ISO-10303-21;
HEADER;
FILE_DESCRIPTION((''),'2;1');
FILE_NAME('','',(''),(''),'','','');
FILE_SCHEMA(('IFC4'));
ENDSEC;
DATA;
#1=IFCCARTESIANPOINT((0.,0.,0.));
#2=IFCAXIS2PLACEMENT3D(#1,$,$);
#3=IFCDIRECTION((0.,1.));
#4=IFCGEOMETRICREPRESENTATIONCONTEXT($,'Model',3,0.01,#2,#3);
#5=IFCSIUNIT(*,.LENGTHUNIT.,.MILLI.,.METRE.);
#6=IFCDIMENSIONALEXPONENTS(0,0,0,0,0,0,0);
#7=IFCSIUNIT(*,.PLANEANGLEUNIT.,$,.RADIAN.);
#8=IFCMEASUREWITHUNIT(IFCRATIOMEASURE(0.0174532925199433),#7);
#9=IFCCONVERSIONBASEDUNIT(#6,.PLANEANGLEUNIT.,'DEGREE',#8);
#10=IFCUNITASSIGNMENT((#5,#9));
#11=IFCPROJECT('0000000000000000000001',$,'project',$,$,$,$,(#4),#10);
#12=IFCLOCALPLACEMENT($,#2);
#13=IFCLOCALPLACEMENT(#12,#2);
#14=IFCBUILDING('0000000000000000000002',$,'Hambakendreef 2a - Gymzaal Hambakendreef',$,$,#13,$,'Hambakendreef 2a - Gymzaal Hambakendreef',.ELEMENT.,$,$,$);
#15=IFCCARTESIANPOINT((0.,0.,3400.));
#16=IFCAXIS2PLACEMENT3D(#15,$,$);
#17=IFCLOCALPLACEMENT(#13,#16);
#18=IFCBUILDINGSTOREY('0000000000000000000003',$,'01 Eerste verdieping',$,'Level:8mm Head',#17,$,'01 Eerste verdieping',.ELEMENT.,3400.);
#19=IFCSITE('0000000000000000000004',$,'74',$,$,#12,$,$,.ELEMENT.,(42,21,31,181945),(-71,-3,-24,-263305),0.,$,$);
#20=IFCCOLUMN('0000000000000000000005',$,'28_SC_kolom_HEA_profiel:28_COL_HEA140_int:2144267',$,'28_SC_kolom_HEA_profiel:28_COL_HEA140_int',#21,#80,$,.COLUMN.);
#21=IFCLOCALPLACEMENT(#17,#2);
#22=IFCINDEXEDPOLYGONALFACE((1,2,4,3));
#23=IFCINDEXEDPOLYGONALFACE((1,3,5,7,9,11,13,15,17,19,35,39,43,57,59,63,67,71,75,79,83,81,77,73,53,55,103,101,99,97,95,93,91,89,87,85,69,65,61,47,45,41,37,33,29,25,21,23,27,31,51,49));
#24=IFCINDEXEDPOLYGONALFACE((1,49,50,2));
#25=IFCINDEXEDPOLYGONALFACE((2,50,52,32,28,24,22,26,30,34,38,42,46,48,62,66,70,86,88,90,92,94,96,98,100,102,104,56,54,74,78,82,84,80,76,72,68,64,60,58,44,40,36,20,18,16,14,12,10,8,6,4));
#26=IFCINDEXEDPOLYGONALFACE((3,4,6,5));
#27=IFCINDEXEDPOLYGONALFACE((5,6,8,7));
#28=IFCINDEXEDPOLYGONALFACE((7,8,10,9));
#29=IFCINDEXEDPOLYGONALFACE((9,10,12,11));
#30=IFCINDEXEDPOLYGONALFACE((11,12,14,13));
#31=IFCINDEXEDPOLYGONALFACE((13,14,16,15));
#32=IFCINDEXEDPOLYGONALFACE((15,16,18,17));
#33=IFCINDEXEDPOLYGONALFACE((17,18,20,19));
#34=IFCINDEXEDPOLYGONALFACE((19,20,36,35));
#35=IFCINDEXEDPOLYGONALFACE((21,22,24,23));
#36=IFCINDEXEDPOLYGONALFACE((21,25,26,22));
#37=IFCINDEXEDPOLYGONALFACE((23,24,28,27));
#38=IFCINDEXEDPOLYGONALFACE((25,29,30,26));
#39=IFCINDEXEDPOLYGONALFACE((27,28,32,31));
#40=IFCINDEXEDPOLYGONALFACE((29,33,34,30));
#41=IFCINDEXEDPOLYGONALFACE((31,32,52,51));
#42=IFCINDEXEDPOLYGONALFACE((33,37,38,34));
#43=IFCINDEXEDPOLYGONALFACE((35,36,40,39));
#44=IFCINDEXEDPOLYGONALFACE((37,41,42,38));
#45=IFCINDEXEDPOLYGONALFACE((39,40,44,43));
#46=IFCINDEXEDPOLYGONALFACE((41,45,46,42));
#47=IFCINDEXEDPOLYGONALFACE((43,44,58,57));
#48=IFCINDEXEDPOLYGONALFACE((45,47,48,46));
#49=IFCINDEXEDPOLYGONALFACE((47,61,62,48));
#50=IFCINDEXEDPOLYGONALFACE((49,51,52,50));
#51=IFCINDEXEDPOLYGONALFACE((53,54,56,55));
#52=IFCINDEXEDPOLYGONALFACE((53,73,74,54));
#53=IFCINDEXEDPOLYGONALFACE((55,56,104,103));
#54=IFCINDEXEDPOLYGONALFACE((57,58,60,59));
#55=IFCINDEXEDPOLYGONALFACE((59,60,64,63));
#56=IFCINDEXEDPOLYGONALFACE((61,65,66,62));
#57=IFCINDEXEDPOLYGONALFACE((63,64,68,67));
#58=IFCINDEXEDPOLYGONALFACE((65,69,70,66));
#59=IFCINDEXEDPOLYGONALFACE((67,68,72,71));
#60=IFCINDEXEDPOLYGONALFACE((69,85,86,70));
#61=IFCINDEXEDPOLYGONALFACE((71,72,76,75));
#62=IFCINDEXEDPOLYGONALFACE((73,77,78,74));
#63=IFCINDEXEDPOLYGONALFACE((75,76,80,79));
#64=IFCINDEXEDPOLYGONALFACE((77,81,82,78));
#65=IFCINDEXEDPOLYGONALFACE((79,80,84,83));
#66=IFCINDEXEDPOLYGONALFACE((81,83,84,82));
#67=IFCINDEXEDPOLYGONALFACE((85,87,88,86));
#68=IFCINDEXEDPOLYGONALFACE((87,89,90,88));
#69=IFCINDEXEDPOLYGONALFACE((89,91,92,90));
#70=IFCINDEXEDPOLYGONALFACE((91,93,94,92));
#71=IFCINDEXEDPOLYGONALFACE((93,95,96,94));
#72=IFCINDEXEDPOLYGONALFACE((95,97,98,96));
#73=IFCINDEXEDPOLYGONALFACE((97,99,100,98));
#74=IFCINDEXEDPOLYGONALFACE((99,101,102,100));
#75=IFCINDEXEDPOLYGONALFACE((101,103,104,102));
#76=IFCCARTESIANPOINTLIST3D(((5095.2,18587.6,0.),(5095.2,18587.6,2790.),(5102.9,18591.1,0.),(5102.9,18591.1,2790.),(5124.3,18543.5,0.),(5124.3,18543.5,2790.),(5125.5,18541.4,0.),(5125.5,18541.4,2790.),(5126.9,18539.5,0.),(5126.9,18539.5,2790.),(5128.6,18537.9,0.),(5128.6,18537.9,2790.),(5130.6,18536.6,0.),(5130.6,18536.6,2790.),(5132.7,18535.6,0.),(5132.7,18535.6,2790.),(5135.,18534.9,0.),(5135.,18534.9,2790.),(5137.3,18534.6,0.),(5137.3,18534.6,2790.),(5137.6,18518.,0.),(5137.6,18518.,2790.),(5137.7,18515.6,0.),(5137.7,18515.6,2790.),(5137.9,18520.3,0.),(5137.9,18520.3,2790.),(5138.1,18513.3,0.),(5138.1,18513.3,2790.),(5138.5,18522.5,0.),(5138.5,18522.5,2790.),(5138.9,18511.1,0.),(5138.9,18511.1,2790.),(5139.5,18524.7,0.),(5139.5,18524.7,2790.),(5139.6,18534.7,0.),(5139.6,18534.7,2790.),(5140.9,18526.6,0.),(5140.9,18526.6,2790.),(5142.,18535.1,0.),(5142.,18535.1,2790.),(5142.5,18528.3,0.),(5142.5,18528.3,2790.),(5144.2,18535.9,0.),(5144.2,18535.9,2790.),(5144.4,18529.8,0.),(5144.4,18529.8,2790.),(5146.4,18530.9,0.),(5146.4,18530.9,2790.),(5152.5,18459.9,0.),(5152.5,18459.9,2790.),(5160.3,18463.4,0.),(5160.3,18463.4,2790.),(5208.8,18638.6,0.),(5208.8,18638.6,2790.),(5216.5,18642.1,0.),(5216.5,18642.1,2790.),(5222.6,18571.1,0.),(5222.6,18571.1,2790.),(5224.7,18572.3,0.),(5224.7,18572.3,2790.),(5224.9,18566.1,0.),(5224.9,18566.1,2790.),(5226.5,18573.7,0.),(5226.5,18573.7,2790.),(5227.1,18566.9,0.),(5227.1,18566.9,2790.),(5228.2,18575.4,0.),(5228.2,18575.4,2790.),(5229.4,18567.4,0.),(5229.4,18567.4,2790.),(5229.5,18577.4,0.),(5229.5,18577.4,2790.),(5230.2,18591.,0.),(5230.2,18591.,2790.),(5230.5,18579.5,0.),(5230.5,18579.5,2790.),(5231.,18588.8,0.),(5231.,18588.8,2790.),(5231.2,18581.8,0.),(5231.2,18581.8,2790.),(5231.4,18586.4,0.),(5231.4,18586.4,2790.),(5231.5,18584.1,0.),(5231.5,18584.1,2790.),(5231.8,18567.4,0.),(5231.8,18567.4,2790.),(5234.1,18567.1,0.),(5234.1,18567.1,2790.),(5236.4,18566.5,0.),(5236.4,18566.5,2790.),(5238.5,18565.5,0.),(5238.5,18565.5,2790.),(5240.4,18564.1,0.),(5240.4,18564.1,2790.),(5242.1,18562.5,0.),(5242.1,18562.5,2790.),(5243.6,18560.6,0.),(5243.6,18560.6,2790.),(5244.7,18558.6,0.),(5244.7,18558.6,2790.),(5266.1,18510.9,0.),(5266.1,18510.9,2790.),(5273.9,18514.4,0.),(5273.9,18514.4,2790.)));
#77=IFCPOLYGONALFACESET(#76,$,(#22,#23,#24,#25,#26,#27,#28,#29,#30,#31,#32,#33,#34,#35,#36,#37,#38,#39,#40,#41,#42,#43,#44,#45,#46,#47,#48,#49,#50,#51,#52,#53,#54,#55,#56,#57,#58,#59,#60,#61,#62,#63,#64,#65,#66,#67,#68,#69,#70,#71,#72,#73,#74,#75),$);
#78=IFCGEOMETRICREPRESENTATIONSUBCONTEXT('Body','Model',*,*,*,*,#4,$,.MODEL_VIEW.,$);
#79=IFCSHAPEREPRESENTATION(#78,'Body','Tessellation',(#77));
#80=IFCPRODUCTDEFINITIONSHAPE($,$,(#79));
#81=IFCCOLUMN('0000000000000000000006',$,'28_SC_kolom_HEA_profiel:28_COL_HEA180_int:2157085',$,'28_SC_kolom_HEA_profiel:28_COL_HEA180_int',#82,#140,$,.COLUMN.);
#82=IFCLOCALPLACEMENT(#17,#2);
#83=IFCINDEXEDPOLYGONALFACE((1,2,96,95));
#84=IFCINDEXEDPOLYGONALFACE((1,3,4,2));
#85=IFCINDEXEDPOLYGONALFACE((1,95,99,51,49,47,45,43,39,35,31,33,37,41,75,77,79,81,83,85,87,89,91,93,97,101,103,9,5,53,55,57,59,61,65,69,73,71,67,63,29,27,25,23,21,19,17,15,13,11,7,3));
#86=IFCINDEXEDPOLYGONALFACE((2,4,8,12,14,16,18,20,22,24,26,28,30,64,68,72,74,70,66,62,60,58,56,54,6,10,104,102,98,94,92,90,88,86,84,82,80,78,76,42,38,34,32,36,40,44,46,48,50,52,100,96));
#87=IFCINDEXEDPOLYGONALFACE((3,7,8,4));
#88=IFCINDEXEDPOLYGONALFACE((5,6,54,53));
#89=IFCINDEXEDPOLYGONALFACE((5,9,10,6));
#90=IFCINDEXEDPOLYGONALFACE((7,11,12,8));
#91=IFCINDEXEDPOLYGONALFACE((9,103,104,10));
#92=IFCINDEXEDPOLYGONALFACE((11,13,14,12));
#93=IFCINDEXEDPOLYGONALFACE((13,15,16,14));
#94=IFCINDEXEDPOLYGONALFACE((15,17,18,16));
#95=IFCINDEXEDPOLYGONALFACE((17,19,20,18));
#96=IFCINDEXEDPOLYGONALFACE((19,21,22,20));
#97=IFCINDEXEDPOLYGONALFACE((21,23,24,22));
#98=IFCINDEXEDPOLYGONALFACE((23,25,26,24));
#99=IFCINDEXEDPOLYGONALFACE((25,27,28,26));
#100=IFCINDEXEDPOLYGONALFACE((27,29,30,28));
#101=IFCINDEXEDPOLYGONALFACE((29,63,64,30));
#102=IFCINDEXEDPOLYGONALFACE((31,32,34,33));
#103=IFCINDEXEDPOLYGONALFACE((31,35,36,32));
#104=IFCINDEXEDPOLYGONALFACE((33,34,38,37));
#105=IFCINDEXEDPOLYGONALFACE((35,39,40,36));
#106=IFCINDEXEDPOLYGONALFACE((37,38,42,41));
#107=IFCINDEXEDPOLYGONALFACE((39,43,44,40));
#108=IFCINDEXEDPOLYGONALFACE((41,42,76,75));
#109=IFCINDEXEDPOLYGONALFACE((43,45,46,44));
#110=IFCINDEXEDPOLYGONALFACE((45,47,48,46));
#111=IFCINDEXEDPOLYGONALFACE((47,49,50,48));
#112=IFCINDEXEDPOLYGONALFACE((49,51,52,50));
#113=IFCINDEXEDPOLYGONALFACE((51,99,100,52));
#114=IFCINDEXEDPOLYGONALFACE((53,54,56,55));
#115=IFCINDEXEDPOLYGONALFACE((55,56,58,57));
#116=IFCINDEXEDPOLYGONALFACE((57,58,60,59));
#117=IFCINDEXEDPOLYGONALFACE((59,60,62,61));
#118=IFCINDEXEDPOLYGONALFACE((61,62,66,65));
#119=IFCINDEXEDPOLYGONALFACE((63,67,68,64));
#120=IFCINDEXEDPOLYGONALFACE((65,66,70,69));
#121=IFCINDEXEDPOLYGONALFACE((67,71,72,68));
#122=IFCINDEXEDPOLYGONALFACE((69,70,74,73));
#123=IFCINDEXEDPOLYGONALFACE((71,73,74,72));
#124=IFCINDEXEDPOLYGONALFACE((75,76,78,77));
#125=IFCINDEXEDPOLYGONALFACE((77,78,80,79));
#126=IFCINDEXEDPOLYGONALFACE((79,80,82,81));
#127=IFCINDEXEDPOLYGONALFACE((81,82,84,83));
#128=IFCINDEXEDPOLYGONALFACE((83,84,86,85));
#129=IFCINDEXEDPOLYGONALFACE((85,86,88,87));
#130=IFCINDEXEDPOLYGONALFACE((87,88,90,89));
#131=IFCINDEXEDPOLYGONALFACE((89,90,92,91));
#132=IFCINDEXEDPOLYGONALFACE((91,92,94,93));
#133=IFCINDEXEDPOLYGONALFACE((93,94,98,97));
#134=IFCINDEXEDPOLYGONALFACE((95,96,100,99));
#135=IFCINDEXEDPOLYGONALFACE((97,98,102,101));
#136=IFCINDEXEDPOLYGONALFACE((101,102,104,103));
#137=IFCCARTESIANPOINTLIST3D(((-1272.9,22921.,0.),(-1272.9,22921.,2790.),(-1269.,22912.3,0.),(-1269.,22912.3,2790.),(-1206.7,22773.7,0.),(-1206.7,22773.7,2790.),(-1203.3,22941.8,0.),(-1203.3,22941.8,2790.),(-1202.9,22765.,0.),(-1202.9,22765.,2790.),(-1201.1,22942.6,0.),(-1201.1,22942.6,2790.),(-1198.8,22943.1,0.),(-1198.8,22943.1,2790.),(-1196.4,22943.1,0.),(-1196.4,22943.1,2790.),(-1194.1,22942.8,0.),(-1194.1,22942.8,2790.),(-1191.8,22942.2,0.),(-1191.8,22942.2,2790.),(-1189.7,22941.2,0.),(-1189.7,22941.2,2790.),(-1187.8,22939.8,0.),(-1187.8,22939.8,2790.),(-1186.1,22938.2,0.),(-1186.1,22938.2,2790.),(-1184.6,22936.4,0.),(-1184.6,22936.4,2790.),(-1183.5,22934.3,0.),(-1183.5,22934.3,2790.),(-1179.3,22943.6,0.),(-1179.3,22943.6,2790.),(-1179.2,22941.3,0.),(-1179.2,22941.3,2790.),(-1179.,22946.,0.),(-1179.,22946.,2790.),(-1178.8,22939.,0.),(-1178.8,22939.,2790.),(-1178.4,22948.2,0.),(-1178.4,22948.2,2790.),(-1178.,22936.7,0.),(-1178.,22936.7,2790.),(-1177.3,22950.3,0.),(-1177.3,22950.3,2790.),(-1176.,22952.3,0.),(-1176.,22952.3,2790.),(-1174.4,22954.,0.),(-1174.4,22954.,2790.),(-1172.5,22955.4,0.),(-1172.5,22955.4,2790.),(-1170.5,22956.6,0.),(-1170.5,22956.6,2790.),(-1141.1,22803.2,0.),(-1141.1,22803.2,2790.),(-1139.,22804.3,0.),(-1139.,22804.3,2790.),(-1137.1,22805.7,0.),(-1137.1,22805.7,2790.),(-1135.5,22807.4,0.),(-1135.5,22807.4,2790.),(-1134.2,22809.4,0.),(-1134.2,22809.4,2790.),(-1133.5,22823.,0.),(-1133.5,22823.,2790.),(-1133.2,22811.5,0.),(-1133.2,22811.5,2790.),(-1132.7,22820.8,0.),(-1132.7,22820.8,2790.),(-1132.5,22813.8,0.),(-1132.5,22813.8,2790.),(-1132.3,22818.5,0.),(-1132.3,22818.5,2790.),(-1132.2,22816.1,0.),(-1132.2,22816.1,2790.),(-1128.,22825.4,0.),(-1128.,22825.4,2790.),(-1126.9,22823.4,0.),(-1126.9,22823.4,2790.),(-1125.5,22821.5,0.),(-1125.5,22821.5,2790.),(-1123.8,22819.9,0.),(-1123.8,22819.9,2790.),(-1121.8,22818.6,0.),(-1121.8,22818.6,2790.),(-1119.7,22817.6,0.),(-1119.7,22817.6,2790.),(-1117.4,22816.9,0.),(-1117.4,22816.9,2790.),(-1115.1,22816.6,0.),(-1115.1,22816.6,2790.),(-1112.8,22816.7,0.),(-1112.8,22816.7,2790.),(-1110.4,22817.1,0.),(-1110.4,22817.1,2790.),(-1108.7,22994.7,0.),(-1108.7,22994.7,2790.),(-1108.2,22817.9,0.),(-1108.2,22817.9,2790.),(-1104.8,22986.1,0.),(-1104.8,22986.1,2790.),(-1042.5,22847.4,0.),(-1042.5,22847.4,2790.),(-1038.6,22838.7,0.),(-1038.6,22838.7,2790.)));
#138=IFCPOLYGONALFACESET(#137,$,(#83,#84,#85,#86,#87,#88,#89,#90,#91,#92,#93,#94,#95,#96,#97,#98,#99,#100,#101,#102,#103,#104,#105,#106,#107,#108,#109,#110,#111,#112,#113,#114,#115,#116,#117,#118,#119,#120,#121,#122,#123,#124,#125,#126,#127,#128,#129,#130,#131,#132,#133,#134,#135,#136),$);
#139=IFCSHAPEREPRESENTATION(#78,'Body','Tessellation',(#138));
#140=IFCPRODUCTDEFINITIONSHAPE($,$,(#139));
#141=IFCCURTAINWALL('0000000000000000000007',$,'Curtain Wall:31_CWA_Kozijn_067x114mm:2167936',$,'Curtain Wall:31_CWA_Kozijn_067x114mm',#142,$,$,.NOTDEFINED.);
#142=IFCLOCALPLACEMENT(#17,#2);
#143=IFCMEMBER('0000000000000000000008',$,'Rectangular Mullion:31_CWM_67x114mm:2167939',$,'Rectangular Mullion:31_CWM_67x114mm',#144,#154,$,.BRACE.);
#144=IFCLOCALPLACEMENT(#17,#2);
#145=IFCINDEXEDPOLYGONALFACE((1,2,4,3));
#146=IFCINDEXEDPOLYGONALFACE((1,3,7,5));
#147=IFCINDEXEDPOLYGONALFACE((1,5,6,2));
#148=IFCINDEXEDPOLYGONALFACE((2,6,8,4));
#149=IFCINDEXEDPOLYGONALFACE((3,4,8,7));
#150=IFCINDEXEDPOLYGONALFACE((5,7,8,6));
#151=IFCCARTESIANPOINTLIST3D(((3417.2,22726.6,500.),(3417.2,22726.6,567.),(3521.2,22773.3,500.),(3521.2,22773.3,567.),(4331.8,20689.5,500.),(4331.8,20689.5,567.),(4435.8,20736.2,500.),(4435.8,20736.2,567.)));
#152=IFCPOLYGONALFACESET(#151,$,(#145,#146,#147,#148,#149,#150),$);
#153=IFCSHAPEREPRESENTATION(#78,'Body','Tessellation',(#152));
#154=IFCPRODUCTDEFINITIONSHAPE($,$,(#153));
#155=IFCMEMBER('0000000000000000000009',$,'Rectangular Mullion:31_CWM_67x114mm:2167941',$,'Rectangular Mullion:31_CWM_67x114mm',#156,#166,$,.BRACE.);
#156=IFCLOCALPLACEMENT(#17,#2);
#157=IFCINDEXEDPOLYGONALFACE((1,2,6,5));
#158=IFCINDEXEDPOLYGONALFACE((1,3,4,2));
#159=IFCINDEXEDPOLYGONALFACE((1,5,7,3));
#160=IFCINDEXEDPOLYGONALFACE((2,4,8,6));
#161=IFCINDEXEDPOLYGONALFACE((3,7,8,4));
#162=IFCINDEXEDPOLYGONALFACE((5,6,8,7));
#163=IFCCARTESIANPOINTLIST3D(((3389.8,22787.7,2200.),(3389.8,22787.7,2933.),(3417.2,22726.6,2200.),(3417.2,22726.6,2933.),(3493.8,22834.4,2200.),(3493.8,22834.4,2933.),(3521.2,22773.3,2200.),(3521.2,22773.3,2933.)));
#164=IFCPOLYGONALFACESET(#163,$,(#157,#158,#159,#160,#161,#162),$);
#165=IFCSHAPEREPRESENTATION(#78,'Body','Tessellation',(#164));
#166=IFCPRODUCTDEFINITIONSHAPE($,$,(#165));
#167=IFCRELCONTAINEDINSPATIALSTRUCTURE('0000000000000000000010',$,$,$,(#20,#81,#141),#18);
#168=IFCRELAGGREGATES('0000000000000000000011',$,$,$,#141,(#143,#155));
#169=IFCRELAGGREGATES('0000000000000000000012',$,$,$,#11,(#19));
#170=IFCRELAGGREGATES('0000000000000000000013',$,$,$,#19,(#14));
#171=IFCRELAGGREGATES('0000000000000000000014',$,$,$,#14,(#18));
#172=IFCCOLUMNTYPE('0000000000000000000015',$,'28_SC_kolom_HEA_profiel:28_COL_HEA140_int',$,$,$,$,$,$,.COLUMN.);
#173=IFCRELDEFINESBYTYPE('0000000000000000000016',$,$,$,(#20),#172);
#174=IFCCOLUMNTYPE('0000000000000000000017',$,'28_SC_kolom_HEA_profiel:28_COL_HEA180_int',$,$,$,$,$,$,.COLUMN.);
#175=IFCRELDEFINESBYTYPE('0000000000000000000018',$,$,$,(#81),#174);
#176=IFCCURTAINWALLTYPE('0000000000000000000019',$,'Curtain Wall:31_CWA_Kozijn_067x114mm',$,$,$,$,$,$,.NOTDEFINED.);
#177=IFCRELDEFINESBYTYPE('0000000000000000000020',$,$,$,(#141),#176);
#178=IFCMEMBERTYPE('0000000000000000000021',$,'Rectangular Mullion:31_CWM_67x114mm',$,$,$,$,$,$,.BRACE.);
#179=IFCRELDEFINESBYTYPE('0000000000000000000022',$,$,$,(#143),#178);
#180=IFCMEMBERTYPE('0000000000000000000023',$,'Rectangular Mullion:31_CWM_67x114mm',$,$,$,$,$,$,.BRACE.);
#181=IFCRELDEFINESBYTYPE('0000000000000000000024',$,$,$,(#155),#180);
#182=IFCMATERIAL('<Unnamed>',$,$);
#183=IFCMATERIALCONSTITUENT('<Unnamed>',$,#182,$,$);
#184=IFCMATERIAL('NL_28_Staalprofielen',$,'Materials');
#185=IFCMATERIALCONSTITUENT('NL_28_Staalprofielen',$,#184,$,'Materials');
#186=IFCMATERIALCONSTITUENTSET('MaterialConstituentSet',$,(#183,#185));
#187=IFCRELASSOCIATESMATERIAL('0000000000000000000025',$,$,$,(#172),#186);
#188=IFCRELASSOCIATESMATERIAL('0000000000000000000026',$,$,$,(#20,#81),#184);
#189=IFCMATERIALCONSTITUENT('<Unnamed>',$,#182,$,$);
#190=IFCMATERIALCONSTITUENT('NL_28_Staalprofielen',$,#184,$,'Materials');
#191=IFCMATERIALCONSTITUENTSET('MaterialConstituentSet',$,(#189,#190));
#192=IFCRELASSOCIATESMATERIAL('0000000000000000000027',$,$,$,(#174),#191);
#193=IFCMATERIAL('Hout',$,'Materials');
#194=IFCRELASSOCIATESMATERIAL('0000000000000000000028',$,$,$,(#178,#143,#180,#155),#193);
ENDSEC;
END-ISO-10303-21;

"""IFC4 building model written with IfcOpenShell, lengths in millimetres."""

from ifc_helpers import new_model, entity, si_unit, converted_unit, direction, frame, origin, place, context, subcontext, project, spatial, indexed_curve, outline, extrude, source, transform, mapped, material, constituent, constituent_set, type_object, type_shapes, element, aggregate, save


model = new_model("IFC4")

# Units and contexts
model_context = context("Model", 3, precision=0.01, world=origin(), true_north=direction((0.0, 1.0)))
body_context = subcontext(model_context, "Body", "Model", "MODEL_VIEW")
ifc_project = project(units=[si_unit("LENGTHUNIT", "METRE", prefix="MILLI"), converted_unit("PLANEANGLEUNIT", "DEGREE", entity("IfcRatioMeasure", 0.0174532925199433), si_unit("PLANEANGLEUNIT", "RADIAN"), dimensions=[0, 0, 0, 0, 0, 0, 0])], contexts=[model_context])

# Site, building, storey
site_placement = place(None, origin())
site = spatial("IfcSite", under=ifc_project, at=site_placement, Name="74", CompositionType="ELEMENT", RefLatitude=(42, 21, 31, 181945), RefLongitude=(-71, -3, -24, -263305), RefElevation=0.0)
building_placement = place(site_placement, origin())
building = spatial("IfcBuilding", under=site, at=building_placement, Name="Hambakendreef 2a - Gymzaal Hambakendreef", LongName="Hambakendreef 2a - Gymzaal Hambakendreef", CompositionType="ELEMENT")
storey_placement = place(building_placement, frame((0.0, 0.0, 3400.0)))
storey = spatial("IfcBuildingStorey", under=building, at=storey_placement, Name="01 Eerste verdieping", ObjectType="Level:8mm Head", LongName="01 Eerste verdieping", CompositionType="ELEMENT", Elevation=3400.0)

# Columns
ifc_material_1 = material(Name="NL_28_Staalprofielen", Category="Materials")
ifc_material_2 = material(Name="<Unnamed>")
ifc_constituent_1 = constituent(ifc_material_2, Name="<Unnamed>")
ifc_constituent_2 = constituent(ifc_material_1, Name="NL_28_Staalprofielen", Category="Materials")
ifc_constituent_set_1 = constituent_set(constituents=[ifc_constituent_1, ifc_constituent_2], Name="MaterialConstituentSet")
column_type_1 = type_object("IfcColumnType", Name="28_SC_kolom_HEA_profiel:28_COL_HEA140_int", PredefinedType="COLUMN", material=ifc_constituent_set_1)
shared_shape_1 = source(origin(), body_context, "Body", "SweptSolid", [
    extrude(outline(indexed_curve([(58.0, -70.0), (66.5, -70.0), (66.5, 70.0), (58.0, 70.0), (58.0, 17.8), (57.8, 15.4), (57.3, 13.1), (56.4, 10.9), (55.1, 8.9), (53.6, 7.1), (51.8, 5.6), (49.8, 4.4), (47.6, 3.5), (45.3, 2.9), (43.0, 2.8), (-43.0, 2.8), (-45.3, 2.9), (-47.6, 3.5), (-49.8, 4.4), (-51.8, 5.6), (-53.6, 7.1), (-55.1, 8.9), (-56.4, 10.9), (-57.3, 13.1), (-57.8, 15.4), (-58.0, 17.7), (-58.0, 70.0), (-66.5, 70.0), (-66.5, -70.0), (-58.0, -70.0), (-58.0, -17.8), (-57.8, -15.4), (-57.3, -13.1), (-56.4, -10.9), (-55.1, -8.9), (-53.6, -7.1), (-51.8, -5.6), (-49.8, -4.4), (-47.6, -3.5), (-45.3, -2.9), (-43.0, -2.7), (43.0, -2.8), (45.3, -2.9), (47.6, -3.5), (49.8, -4.4), (51.8, -5.6), (53.6, -7.1), (55.1, -8.9), (56.4, -10.9), (57.3, -13.1), (57.8, -15.4), (58.0, -17.8), (58.0, -70.0)], self_intersect=False)), frame((0.0, 0.0, 3400.0), z_axis=(0.0, 0.0, 1.0), x_axis=(0.0, -1.0, 0.0)), (0.0, 0.0, 1.0), 2790.0),
])
type_shapes(column_type_1, [shared_shape_1])
column_1_placement = place(storey_placement, frame((5184.5, 18551.0, -3400.0), z_axis=(0.0, 0.0, 1.0), x_axis=(0.40959, -0.91227, 0.0)))
element("IfcColumn", 1, at=column_1_placement, inside=storey, type_object=column_type_1, material=ifc_material_1, Name="28_SC_kolom_HEA_profiel:28_COL_HEA140_int:2144267", ObjectType="28_SC_kolom_HEA_profiel:28_COL_HEA140_int", PredefinedType="COLUMN", context=body_context, shape_type="MappedRepresentation", body=[
    mapped(shared_shape_1, transform((0.0, 0.0, 0.0), scale=1.0)),
])
ifc_constituent_3 = constituent(ifc_material_2, Name="<Unnamed>")
ifc_constituent_4 = constituent(ifc_material_1, Name="NL_28_Staalprofielen", Category="Materials")
ifc_constituent_set_2 = constituent_set(constituents=[ifc_constituent_3, ifc_constituent_4], Name="MaterialConstituentSet")
column_type_2 = type_object("IfcColumnType", Name="28_SC_kolom_HEA_profiel:28_COL_HEA180_int", PredefinedType="COLUMN", material=ifc_constituent_set_2)
shared_shape_2 = source(origin(), body_context, "Body", "SweptSolid", [
    extrude(outline(indexed_curve([(-85.5, -90.0), (-76.0, -90.0), (-76.0, -18.0), (-75.8, -15.7), (-75.3, -13.4), (-74.4, -11.2), (-73.1, -9.2), (-71.6, -7.4), (-69.8, -5.9), (-67.8, -4.6), (-65.6, -3.7), (-63.3, -3.2), (-61.0, -3.0), (61.0, -3.0), (63.3, -3.2), (65.6, -3.7), (67.8, -4.6), (69.8, -5.9), (71.6, -7.4), (73.1, -9.2), (74.4, -11.2), (75.3, -13.4), (75.8, -15.7), (76.0, -18.0), (76.0, -90.0), (85.5, -90.0), (85.5, 90.0), (76.0, 90.0), (76.0, 18.0), (75.8, 15.7), (75.3, 13.4), (74.4, 11.2), (73.1, 9.2), (71.6, 7.4), (69.8, 5.9), (67.8, 4.6), (65.6, 3.7), (63.3, 3.2), (61.0, 3.0), (-61.0, 3.0), (-63.3, 3.2), (-65.6, 3.7), (-67.8, 4.6), (-69.8, 5.9), (-71.6, 7.4), (-73.1, 9.2), (-74.4, 11.2), (-75.3, 13.4), (-75.8, 15.7), (-76.0, 18.0), (-76.0, 90.0), (-85.5, 90.0), (-85.5, -90.0)], self_intersect=False)), frame((0.0, 0.0, 3400.0), z_axis=(0.0, 0.0, 1.0), x_axis=(0.0, -1.0, 0.0)), (0.0, 0.0, 1.0), 2790.0),
])
type_shapes(column_type_2, [shared_shape_2])
column_2_placement = place(storey_placement, frame((-1155.8, 22879.9, -3400.0), z_axis=(0.0, 0.0, 1.0), x_axis=(0.91227, 0.40959, 0.0)))
element("IfcColumn", 2, at=column_2_placement, inside=storey, type_object=column_type_2, material=ifc_material_1, Name="28_SC_kolom_HEA_profiel:28_COL_HEA180_int:2157085", ObjectType="28_SC_kolom_HEA_profiel:28_COL_HEA180_int", PredefinedType="COLUMN", context=body_context, shape_type="MappedRepresentation", body=[
    mapped(shared_shape_2, transform((0.0, 0.0, 0.0), scale=1.0)),
])

# Curtain wall, members
curtain_wall_type = type_object("IfcCurtainWallType", Name="Curtain Wall:31_CWA_Kozijn_067x114mm", PredefinedType="NOTDEFINED")
curtain_wall_placement = place(storey_placement, frame((0.0, 0.0, -3400.0)))
curtain_wall = element("IfcCurtainWall", 3, at=curtain_wall_placement, inside=storey, type_object=curtain_wall_type, Name="Curtain Wall:31_CWA_Kozijn_067x114mm:2167936", ObjectType="Curtain Wall:31_CWA_Kozijn_067x114mm", PredefinedType="NOTDEFINED")
ifc_material_3 = material(Name="Hout", Category="Materials")
member_type_1 = type_object("IfcMemberType", Name="Rectangular Mullion:31_CWM_67x114mm", PredefinedType="BRACE", material=ifc_material_3)
shared_shape_3 = source(origin(), body_context, "Body", "SweptSolid", [
    extrude(outline(indexed_curve([(-57.0, -33.5), (57.0, -33.5), (57.0, 33.5), (-57.0, 33.5), (-57.0, -33.5)], self_intersect=False)), frame((-33.5, 0.0, -2233.0), z_axis=(0.0, 0.0, 1.0), x_axis=(0.0, -1.0, 0.0)), (0.0, 0.0, 1.0), 2233.0),
])
type_shapes(member_type_1, [shared_shape_3])
member_1_placement = place(storey_placement, frame((3469.2, 22749.9, 500.0), z_axis=(-0.40959, 0.91227, 0.0), x_axis=(0.0, 0.0, -1.0)))
member_1 = element("IfcMember", 4, at=member_1_placement, type_object=member_type_1, material=ifc_material_3, Name="Rectangular Mullion:31_CWM_67x114mm:2167939", ObjectType="Rectangular Mullion:31_CWM_67x114mm", PredefinedType="BRACE", context=body_context, shape_type="MappedRepresentation", body=[
    mapped(shared_shape_3, transform((0.0, 0.0, 0.0), scale=1.0)),
])
member_type_2 = type_object("IfcMemberType", Name="Rectangular Mullion:31_CWM_67x114mm", PredefinedType="BRACE", material=ifc_material_3)
shared_shape_4 = source(origin(), body_context, "Body", "SweptSolid", [
    extrude(outline(indexed_curve([(-57.0, -33.5), (57.0, -33.5), (57.0, 33.5), (-57.0, 33.5), (-57.0, -33.5)], self_intersect=False)), frame((-33.5, 0.0, -733.0), z_axis=(0.0, 0.0, 1.0), x_axis=(0.0, -1.0, 0.0)), (0.0, 0.0, 1.0), 733.0),
])
type_shapes(member_type_2, [shared_shape_4])
member_2_placement = place(storey_placement, frame((3441.8, 22811.0, 2933.0), z_axis=(0.0, 0.0, 1.0), x_axis=(-0.40959, 0.91227, 0.0)))
member_2 = element("IfcMember", 5, at=member_2_placement, type_object=member_type_2, material=ifc_material_3, Name="Rectangular Mullion:31_CWM_67x114mm:2167941", ObjectType="Rectangular Mullion:31_CWM_67x114mm", PredefinedType="BRACE", context=body_context, shape_type="MappedRepresentation", body=[
    mapped(shared_shape_4, transform((0.0, 0.0, 0.0), scale=1.0)),
])
aggregate(curtain_wall, [member_1, member_2])

save(model, "model.ifc")
